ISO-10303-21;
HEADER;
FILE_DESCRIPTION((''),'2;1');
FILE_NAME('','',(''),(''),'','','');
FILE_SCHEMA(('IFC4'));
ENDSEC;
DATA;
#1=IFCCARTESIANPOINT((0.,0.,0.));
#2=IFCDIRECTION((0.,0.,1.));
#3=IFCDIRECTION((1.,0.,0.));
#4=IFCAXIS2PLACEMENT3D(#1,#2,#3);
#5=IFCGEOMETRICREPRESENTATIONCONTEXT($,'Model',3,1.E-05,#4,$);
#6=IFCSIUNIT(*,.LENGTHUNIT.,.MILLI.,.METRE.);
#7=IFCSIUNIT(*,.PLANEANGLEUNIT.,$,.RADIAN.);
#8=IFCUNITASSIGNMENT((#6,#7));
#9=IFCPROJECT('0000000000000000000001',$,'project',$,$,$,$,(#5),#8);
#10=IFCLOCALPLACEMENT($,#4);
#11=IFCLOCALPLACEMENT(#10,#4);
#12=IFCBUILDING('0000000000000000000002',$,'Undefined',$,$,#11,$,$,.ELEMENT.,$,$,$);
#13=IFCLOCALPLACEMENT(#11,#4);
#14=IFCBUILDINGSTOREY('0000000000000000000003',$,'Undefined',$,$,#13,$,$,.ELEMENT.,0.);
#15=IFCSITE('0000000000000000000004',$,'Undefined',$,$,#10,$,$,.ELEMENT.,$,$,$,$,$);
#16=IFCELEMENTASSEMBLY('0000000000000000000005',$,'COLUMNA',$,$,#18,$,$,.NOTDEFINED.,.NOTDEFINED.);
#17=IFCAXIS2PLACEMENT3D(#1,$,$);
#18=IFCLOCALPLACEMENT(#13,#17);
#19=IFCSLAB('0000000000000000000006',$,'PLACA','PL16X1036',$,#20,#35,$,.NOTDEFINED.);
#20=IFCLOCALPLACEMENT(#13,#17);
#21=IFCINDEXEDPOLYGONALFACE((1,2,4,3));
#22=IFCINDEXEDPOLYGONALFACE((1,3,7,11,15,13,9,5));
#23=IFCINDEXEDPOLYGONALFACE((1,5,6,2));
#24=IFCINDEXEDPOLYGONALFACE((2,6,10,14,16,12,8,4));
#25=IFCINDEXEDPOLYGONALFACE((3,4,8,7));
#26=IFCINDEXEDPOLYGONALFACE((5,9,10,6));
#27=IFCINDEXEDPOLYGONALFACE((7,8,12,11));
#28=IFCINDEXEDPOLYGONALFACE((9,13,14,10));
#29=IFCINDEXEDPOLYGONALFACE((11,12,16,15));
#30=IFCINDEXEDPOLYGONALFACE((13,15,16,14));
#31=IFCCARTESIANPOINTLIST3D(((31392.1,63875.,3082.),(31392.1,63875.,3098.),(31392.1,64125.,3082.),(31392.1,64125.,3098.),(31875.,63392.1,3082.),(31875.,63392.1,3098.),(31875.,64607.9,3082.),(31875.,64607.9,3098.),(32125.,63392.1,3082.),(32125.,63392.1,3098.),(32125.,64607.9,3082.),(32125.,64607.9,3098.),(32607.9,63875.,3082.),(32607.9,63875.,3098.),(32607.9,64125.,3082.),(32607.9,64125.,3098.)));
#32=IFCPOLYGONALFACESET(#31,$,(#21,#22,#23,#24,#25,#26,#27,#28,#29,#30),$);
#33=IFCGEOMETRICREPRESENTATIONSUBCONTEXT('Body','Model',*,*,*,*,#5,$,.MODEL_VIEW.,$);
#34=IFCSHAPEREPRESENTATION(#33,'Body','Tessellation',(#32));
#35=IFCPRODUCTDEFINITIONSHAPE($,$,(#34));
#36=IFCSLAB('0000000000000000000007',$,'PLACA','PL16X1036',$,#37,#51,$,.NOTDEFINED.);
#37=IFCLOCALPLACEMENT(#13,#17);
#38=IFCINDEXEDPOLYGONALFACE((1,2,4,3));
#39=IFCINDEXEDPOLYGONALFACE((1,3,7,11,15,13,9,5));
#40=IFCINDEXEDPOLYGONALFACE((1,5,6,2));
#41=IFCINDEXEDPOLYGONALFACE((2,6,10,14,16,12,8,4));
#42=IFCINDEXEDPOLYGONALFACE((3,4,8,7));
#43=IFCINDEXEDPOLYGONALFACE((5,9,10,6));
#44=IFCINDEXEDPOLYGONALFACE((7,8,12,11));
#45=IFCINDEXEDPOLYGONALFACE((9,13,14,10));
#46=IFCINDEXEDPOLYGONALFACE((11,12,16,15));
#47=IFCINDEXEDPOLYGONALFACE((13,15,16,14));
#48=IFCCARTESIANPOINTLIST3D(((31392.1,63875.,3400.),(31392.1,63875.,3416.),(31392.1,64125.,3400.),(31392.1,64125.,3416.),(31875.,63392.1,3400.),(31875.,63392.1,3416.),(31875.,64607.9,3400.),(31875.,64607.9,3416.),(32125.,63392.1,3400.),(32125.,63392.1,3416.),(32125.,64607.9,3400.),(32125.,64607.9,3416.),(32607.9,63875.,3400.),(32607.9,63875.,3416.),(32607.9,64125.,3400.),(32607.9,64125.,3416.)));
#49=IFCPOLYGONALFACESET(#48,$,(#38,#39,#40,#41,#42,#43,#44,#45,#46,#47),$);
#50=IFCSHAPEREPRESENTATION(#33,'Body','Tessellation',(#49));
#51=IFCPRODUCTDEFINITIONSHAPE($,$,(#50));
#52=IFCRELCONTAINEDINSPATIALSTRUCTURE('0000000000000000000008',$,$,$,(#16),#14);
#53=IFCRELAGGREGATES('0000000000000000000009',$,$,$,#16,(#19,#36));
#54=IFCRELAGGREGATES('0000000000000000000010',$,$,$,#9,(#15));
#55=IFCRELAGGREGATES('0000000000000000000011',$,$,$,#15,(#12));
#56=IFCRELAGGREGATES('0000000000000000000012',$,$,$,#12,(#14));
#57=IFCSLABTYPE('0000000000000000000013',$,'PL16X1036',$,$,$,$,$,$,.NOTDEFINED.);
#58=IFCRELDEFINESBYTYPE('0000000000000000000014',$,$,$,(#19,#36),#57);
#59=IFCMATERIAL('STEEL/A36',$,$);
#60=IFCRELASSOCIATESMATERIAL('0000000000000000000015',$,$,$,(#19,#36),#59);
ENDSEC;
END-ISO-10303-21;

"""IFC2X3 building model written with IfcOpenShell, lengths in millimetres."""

from ifc_helpers import new_model, si_unit, frame, origin_with_axes, place, context, subcontext, project, spatial, polyline, outline, extrude, material, type_object, element, aggregate, save


model = new_model("IFC2X3")

# Units and contexts
model_context = context("Model", 3, precision=1e-05, world=origin_with_axes())
body_context = subcontext(model_context, "Body", "Model", "MODEL_VIEW")
ifc_project = project(units=[si_unit("LENGTHUNIT", "METRE", prefix="MILLI"), si_unit("PLANEANGLEUNIT", "RADIAN")], contexts=[model_context])

# Site, building, storey
site_placement = place(None, origin_with_axes())
site = spatial("IfcSite", under=ifc_project, at=site_placement, Name="Undefined", CompositionType="ELEMENT")
building_placement = place(site_placement, origin_with_axes())
building = spatial("IfcBuilding", under=site, at=building_placement, Name="Undefined", CompositionType="ELEMENT")
storey_placement = place(building_placement, origin_with_axes())
storey = spatial("IfcBuildingStorey", under=building, at=storey_placement, Name="Undefined", CompositionType="ELEMENT", Elevation=0.0)

# Shared definitions
ifc_material_1 = material(Name="STEEL/A36")

# Element assembly
assembly_1_placement = place(storey_placement, origin_with_axes())
assembly_1 = element("IfcElementAssembly", 1, at=assembly_1_placement, inside=storey, Name="COLUMNA", AssemblyPlace="NOTDEFINED", PredefinedType="NOTDEFINED")

# Slabs
slab_type = type_object("IfcSlabType", Name="PL16X1036", PredefinedType="NOTDEFINED")
slab_1_placement = place(assembly_1_placement, frame((32125.0, 63392.1, 3090.0), z_axis=(0.0, 0.0, 1.0), x_axis=(0.707107, 0.707107, 0.0)))
slab_1 = element("IfcSlab", 2, at=slab_1_placement, type_object=slab_type, material=ifc_material_1, Name="PLACA", Description="PL16X1036", PredefinedType="NOTDEFINED", context=body_context, shape_type="SweptSolid", body=[
    extrude(outline(polyline([(0.0, 0.0), (682.9, 0.0), (859.7, 176.8), (859.7, 859.7), (682.9, 1036.5), (0.0, 1036.5), (-176.8, 859.7), (-176.8, 176.8), (0.0, 0.0)])), frame((0.0, 0.0, -8.0), z_axis=(0.0, 0.0, 1.0), x_axis=(1.0, 0.0, 0.0)), (0.0, 0.0, 1.0), 16.0),
])
slab_2_placement = place(assembly_1_placement, frame((32125.0, 63392.1, 3408.0), z_axis=(0.0, 0.0, 1.0), x_axis=(0.707107, 0.707107, 0.0)))
slab_2 = element("IfcSlab", 3, at=slab_2_placement, type_object=slab_type, material=ifc_material_1, Name="PLACA", Description="PL16X1036", PredefinedType="NOTDEFINED", context=body_context, shape_type="SweptSolid", body=[
    extrude(outline(polyline([(0.0, 0.0), (682.9, 0.0), (859.7, 176.8), (859.7, 859.7), (682.9, 1036.5), (0.0, 1036.5), (-176.8, 859.7), (-176.8, 176.8), (0.0, 0.0)])), frame((0.0, 0.0, -8.0), z_axis=(0.0, 0.0, 1.0), x_axis=(1.0, 0.0, 0.0)), (0.0, 0.0, 1.0), 16.0),
])

aggregate(assembly_1, [slab_1, slab_2])

save(model, "model.ifc")
